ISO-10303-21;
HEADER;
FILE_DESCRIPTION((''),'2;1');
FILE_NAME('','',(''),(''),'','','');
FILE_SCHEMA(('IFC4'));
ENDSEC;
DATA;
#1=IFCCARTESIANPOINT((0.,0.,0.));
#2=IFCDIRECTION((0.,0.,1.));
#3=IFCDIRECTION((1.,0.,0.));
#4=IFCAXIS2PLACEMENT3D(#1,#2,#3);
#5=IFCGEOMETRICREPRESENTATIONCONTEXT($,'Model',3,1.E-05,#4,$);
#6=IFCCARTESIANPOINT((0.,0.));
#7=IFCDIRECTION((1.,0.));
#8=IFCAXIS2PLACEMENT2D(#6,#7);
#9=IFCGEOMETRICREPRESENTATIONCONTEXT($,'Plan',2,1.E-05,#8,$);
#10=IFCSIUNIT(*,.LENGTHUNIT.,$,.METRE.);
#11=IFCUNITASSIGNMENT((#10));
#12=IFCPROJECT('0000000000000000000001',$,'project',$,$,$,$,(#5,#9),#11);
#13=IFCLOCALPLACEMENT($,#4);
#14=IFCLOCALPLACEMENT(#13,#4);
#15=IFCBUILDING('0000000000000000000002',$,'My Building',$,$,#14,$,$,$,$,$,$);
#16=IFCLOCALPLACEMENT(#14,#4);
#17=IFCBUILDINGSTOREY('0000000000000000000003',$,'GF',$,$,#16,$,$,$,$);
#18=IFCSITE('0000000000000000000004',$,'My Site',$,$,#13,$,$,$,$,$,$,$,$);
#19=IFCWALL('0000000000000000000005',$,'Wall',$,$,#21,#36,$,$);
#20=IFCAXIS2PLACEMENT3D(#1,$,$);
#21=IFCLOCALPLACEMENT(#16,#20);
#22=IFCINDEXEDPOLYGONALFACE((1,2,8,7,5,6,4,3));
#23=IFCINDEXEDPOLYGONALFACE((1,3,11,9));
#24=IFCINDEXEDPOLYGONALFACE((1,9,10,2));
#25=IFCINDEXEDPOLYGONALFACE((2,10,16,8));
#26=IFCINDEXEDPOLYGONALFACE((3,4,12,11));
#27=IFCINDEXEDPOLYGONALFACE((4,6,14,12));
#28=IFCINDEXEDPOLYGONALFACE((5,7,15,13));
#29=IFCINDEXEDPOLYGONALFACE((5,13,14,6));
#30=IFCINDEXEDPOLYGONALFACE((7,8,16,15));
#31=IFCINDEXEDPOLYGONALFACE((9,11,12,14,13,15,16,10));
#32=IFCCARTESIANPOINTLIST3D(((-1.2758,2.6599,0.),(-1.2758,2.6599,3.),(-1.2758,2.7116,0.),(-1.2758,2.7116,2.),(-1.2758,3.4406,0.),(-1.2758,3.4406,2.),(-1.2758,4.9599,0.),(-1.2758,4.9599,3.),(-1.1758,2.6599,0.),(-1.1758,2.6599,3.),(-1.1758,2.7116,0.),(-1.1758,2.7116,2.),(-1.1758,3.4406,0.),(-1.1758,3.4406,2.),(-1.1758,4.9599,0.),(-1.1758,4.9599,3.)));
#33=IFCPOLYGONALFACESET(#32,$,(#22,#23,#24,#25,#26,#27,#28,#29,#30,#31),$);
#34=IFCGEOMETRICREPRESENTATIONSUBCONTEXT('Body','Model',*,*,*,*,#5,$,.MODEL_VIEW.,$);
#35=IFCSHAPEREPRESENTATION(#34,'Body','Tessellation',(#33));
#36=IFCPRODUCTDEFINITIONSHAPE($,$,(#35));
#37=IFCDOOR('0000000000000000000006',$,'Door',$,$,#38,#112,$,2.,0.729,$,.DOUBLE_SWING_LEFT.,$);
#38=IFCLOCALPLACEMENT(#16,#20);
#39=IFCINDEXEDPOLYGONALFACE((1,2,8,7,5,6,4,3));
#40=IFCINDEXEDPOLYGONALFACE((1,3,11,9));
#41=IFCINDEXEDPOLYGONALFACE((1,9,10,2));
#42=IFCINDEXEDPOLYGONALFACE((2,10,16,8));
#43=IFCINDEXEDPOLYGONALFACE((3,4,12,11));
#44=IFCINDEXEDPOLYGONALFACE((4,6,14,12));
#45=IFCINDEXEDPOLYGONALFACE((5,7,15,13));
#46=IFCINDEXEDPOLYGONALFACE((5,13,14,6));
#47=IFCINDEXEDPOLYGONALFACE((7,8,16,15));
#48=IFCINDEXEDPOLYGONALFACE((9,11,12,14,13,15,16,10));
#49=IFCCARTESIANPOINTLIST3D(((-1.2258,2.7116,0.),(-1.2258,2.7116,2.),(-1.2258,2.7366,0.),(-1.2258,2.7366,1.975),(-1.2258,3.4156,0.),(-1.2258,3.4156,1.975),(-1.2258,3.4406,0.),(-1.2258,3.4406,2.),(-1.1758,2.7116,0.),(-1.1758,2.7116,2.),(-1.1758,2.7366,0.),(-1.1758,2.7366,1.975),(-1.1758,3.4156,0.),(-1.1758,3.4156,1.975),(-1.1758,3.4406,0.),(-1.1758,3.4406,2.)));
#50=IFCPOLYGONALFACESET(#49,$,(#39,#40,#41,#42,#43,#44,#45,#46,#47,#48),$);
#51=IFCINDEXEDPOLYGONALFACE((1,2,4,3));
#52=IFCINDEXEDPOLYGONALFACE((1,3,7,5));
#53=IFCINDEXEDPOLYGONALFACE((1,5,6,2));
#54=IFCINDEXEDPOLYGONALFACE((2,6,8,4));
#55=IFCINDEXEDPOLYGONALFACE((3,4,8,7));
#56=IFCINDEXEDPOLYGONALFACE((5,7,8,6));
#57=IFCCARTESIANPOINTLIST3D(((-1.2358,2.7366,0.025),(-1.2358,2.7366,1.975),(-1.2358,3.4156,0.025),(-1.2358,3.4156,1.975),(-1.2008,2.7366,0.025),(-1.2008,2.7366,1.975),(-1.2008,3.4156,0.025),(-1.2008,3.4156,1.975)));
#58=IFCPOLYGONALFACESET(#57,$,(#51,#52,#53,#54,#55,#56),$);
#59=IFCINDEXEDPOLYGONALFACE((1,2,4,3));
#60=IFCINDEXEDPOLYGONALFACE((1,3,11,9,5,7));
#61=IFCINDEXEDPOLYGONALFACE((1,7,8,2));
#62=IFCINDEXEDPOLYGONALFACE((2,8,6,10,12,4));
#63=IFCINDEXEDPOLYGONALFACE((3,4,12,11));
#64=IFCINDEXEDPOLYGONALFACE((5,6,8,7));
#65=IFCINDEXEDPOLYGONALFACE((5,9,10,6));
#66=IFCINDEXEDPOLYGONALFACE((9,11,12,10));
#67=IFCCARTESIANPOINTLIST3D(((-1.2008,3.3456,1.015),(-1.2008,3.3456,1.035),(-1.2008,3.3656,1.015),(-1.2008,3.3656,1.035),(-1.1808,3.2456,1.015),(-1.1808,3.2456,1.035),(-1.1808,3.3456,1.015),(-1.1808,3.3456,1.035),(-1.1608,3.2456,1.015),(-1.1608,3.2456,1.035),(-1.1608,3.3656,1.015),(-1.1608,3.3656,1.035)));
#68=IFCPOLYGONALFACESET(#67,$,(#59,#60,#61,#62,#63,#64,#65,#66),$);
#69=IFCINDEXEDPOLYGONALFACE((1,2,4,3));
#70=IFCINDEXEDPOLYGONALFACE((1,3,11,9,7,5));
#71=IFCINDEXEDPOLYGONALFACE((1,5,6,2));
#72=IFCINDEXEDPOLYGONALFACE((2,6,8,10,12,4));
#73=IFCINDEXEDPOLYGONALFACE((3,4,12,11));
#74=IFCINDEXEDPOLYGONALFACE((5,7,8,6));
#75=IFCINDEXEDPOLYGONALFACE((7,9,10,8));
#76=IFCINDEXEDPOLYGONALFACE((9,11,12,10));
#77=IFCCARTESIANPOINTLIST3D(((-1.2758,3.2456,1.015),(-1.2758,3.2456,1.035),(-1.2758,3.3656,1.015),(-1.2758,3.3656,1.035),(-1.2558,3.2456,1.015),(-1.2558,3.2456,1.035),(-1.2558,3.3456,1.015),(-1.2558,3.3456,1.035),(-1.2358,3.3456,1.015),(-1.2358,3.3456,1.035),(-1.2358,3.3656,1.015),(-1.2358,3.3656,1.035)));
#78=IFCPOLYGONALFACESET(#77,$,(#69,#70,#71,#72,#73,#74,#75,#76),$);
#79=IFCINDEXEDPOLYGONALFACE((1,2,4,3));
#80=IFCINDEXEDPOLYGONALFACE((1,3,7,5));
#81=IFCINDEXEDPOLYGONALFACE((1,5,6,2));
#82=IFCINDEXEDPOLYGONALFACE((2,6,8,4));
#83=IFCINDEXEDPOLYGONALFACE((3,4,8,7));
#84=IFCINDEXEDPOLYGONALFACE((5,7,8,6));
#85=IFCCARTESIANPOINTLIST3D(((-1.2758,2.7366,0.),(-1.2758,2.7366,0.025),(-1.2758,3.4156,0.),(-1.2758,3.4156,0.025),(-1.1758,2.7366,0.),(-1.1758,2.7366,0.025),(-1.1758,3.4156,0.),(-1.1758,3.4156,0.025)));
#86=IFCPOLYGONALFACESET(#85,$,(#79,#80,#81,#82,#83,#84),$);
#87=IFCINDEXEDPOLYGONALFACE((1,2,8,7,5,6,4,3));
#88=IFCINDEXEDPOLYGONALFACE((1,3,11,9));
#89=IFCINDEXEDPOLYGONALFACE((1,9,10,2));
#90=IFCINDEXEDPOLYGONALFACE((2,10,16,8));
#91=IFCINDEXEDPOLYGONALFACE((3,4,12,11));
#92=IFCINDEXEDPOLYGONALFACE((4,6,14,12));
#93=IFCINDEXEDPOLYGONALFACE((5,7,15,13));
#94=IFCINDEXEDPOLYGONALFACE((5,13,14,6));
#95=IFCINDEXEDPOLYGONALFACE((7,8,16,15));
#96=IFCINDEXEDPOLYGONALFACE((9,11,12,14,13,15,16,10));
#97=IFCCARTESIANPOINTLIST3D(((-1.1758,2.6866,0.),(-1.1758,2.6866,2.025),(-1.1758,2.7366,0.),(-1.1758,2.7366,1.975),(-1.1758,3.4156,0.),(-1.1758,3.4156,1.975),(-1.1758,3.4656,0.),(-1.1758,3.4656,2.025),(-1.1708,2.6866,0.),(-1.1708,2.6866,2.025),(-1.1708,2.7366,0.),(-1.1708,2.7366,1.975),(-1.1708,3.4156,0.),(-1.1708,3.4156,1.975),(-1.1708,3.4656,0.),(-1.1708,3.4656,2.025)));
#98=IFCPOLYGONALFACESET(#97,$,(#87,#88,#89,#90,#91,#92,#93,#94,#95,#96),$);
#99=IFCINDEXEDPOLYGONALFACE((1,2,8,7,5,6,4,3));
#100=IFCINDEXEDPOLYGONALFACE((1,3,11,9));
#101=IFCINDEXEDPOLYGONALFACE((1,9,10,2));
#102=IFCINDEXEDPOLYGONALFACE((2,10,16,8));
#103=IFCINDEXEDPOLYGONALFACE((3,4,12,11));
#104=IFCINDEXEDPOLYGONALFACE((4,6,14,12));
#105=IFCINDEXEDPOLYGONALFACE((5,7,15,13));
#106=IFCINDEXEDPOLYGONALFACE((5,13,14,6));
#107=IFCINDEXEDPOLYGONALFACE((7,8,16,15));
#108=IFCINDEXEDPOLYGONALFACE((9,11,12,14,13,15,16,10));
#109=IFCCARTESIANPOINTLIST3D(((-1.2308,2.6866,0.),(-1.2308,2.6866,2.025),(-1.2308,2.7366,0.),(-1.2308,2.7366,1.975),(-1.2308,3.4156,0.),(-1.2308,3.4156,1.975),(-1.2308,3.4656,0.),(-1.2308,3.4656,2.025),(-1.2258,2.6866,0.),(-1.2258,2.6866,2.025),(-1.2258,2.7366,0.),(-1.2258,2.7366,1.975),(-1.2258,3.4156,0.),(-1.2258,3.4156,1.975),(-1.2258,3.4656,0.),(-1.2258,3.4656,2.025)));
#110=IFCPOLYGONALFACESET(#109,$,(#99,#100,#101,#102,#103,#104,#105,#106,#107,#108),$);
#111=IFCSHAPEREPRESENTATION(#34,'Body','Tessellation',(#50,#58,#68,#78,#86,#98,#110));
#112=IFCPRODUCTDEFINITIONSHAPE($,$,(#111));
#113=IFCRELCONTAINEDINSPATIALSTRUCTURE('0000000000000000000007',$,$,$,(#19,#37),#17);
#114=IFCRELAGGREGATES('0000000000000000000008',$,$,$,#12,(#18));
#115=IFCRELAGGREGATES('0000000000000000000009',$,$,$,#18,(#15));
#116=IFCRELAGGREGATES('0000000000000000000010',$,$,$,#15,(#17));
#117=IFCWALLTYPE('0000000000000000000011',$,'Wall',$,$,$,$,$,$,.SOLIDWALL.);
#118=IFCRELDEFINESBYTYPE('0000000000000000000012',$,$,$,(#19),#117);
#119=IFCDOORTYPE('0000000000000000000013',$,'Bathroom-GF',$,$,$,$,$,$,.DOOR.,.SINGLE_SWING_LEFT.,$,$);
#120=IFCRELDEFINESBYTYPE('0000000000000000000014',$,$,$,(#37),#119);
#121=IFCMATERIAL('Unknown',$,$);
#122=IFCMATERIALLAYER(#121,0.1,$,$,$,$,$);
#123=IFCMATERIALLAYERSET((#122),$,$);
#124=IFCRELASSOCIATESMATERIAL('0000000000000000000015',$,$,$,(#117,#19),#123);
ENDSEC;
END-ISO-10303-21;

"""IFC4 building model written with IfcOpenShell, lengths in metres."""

from ifc_helpers import new_model, entity, si_unit, frame, origin_with_axes, origin_2d_with_axis, place, context, subcontext, project, spatial, line, indexed_curve, outline, extrude, shape, source, transform, mapped, material, layer, layer_set, layer_usage, type_object, type_shapes, element, fill, save


model = new_model("IFC4")

# Units and contexts
model_context = context("Model", 3, precision=1e-05, world=origin_with_axes())
plan_context = context("Plan", 2, precision=1e-05, world=origin_2d_with_axis())
body_context_1 = subcontext(model_context, "Body", "Model", "MODEL_VIEW")
body_context_2 = subcontext(plan_context, "Body", "Plan", "PLAN_VIEW")
ifc_project = project(units=[si_unit("LENGTHUNIT", "METRE")], contexts=[model_context, plan_context])

# Site, building, storey
site_placement = place(None, origin_with_axes())
site = spatial("IfcSite", under=ifc_project, at=site_placement, Name="My Site")
building_placement = place(site_placement, origin_with_axes())
building = spatial("IfcBuilding", under=site, at=building_placement, Name="My Building")
storey_placement = place(building_placement, origin_with_axes())
storey = spatial("IfcBuildingStorey", under=building, at=storey_placement, Name="GF")

# Shared definitions
ifc_material = material(Name="Unknown")

# Shared definitions
ifc_layer_1 = layer(ifc_material, 0.1)
ifc_layer_set_1 = layer_set([ifc_layer_1])
wall_type = type_object("IfcWallType", Name="Wall", PredefinedType="SOLIDWALL", material=ifc_layer_set_1)

# Wall, opening, door
ifc_layer_usage_1 = layer_usage(ifc_layer_set_1, "AXIS2", "POSITIVE", 0.0)
wall_1_placement = place(storey_placement, frame((-1.1758, 2.6599, 0.0), z_axis=(0.0, 0.0, 1.0), x_axis=(0.0, 1.0, 0.0)))
wall_1 = element("IfcWall", 1, at=wall_1_placement, inside=storey, type_object=wall_type, material=ifc_layer_usage_1, Name="Wall", context=body_context_1, shape_type="SweptSolid", body=[
    extrude(outline(indexed_curve([(0.0, 0.0), (0.0, 0.1), (2.3, 0.1), (2.3, 0.0)], segments=[line(1, 2, 3, 4, 1)])), origin_with_axes(), (0.0, 0.0, 1.0), 3.0),
])
shared_shape_1 = source(origin_with_axes(), body_context_1, "Body", "SweptSolid", [
    extrude(outline(indexed_curve([(0.0, 0.0), (0.729, 0.0), (0.729, 2.0), (0.0, 2.0)], segments=[line(1, 2, 3, 4, 1)])), frame((0.0, -0.6, 0.0), z_axis=(0.0, -1.0, 0.0), x_axis=(1.0, 0.0, 0.0)), (0.0, 0.0, -1.0), 1.2),
])
opening_1_placement = place(wall_1_placement, frame((0.0517, 0.0, 0.0), z_axis=(0.0, 0.0, 1.0), x_axis=(1.0, 0.0, 0.0)))
opening_1 = element("IfcOpeningElement", 2, at=opening_1_placement, cuts=wall_1, PredefinedType="OPENING", context=body_context_1, shape_type="MappedRepresentation", body=[
    mapped(shared_shape_1, transform((0.0, 0.0, 0.0), x_axis=(1.0, 0.0, 0.0), y_axis=(0.0, 1.0, 0.0), z_axis=(0.0, 0.0, 1.0), scale=1.0)),
])
door_type_1 = type_object("IfcDoorType", Name="Bathroom-GF", OperationType="SINGLE_SWING_LEFT", PredefinedType="DOOR")
shared_shape_2 = source(origin_with_axes(), body_context_1, "Body", "SweptSolid", [
    extrude(outline(indexed_curve([(0.0, 0.0), (0.0, 2.0), (0.729, 2.0), (0.729, 0.0), (0.704, 0.0), (0.704, 1.975), (0.025, 1.975), (0.025, 0.0)], segments=[line(1, 2, 3, 4, 5, 6, 7, 8, 1)])), frame((0.0, 0.0, 0.0), z_axis=(0.0, -1.0, 0.0), x_axis=(1.0, 0.0, 0.0)), (0.0, 0.0, -1.0), 0.05),
    extrude(outline(indexed_curve([(0.0, 0.0), (0.679, 0.0), (0.679, 0.035), (0.0, 0.035)], segments=[line(1, 2, 3, 4, 1)])), frame((0.025, 0.025, 0.025), z_axis=(0.0, 0.0, 1.0), x_axis=(1.0, 0.0, 0.0)), (0.0, 0.0, 1.0), 1.95),
    extrude(outline(indexed_curve([(0.0, 0.0), (0.0, -0.04), (-0.12, -0.04), (-0.12, -0.02), (-0.02, -0.02), (-0.02, 0.0)], segments=[line(1, 2, 3, 4, 5, 6, 1)])), frame((0.654, 0.025, 1.015), z_axis=(0.0, 0.0, 1.0), x_axis=(1.0, 0.0, 0.0)), (0.0, 0.0, 1.0), 0.02),
    extrude(outline(indexed_curve([(0.0, 0.0), (0.0, 0.04), (-0.12, 0.04), (-0.12, 0.02), (-0.02, 0.02), (-0.02, 0.0)], segments=[line(1, 2, 3, 4, 5, 6, 1)])), frame((0.654, 0.06, 1.015), z_axis=(0.0, 0.0, 1.0), x_axis=(1.0, 0.0, 0.0)), (0.0, 0.0, 1.0), 0.02),
    extrude(outline(indexed_curve([(0.0, 0.0), (0.679, 0.0), (0.679, 0.1), (0.0, 0.1)], segments=[line(1, 2, 3, 4, 1)])), frame((0.025, 0.0, 0.0), z_axis=(0.0, 0.0, 1.0), x_axis=(1.0, 0.0, 0.0)), (0.0, 0.0, 1.0), 0.025),
    extrude(outline(indexed_curve([(0.0, 0.0), (0.0, 2.025), (0.779, 2.025), (0.779, 0.0), (0.729, 0.0), (0.729, 1.975), (0.05, 1.975), (0.05, 0.0)], segments=[line(1, 2, 3, 4, 5, 6, 7, 8, 1)])), frame((-0.025, -0.005, 0.0), z_axis=(0.0, -1.0, 0.0), x_axis=(1.0, 0.0, 0.0)), (0.0, 0.0, -1.0), 0.005),
    extrude(outline(indexed_curve([(0.0, 0.0), (0.0, 2.025), (0.779, 2.025), (0.779, 0.0), (0.729, 0.0), (0.729, 1.975), (0.05, 1.975), (0.05, 0.0)], segments=[line(1, 2, 3, 4, 5, 6, 7, 8, 1)])), frame((-0.025, 0.05, 0.0), z_axis=(0.0, -1.0, 0.0), x_axis=(1.0, 0.0, 0.0)), (0.0, 0.0, -1.0), 0.005),
])
shared_shape_3 = source(origin_with_axes(), body_context_2, "Body", "Curve2D", [
    entity("IfcIndexedPolyCurve", entity("IfcCartesianPointList2D", [[0.0, 0.0], [0.025, 0.0], [0.025, 0.05], [0.0, 0.05]]), [entity("IfcLineIndex", [1, 2, 3, 4, 1])]),
    entity("IfcIndexedPolyCurve", entity("IfcCartesianPointList2D", [[0.729, 0.0], [0.704, 0.0], [0.704, 0.05], [0.729, 0.05]]), [entity("IfcLineIndex", [1, 2, 3, 4, 1])]),
    entity("IfcIndexedPolyCurve", entity("IfcCartesianPointList2D", [[0.025, 0.05], [0.025, -0.629], [0.06, -0.629]])),
    entity("IfcTrimmedCurve", entity("IfcEllipse", entity("IfcAxis2Placement2D", entity("IfcCartesianPoint", [0.06, 0.05]), entity("IfcDirection", [1.0, 0.0])), 0.644, 0.679), [entity("IfcCartesianPoint", [0.06, -0.629])], [entity("IfcCartesianPoint", [0.06, 0.729])], True, "CARTESIAN"),
    entity("IfcIndexedPolyCurve", entity("IfcCartesianPointList2D", [[0.025, 0.05], [0.06, 0.05], [0.06, 0.729], [0.025, 0.729]]), [entity("IfcLineIndex", [1, 2, 3, 4, 1])]),
])
type_shapes(door_type_1, [shared_shape_2, shared_shape_3])
door_1_placement = place(opening_1_placement, frame((0.0, 0.0, 0.0), z_axis=(0.0, 0.0, 1.0), x_axis=(1.0, 0.0, 0.0)))
door_1 = element("IfcDoor", 3, at=door_1_placement, inside=storey, type_object=door_type_1, Name="Door", OperationType="DOUBLE_SWING_LEFT", OverallHeight=2.0, OverallWidth=0.729, shapes=[
    shape(body_context_1, "Body", "MappedRepresentation", [mapped(shared_shape_2, transform((0.0, 0.0, 0.0), x_axis=(1.0, 0.0, 0.0), y_axis=(0.0, 1.0, 0.0), z_axis=(0.0, 0.0, 1.0), scale=1.0))]),
    shape(body_context_2, "Body", "MappedRepresentation", [mapped(shared_shape_3, transform((0.0, 0.0, 0.0), x_axis=(1.0, 0.0, 0.0), y_axis=(0.0, 1.0, 0.0), z_axis=(0.0, 0.0, 1.0), scale=1.0))]),
])
fill(opening_1, door_1)

save(model, "model.ifc")
